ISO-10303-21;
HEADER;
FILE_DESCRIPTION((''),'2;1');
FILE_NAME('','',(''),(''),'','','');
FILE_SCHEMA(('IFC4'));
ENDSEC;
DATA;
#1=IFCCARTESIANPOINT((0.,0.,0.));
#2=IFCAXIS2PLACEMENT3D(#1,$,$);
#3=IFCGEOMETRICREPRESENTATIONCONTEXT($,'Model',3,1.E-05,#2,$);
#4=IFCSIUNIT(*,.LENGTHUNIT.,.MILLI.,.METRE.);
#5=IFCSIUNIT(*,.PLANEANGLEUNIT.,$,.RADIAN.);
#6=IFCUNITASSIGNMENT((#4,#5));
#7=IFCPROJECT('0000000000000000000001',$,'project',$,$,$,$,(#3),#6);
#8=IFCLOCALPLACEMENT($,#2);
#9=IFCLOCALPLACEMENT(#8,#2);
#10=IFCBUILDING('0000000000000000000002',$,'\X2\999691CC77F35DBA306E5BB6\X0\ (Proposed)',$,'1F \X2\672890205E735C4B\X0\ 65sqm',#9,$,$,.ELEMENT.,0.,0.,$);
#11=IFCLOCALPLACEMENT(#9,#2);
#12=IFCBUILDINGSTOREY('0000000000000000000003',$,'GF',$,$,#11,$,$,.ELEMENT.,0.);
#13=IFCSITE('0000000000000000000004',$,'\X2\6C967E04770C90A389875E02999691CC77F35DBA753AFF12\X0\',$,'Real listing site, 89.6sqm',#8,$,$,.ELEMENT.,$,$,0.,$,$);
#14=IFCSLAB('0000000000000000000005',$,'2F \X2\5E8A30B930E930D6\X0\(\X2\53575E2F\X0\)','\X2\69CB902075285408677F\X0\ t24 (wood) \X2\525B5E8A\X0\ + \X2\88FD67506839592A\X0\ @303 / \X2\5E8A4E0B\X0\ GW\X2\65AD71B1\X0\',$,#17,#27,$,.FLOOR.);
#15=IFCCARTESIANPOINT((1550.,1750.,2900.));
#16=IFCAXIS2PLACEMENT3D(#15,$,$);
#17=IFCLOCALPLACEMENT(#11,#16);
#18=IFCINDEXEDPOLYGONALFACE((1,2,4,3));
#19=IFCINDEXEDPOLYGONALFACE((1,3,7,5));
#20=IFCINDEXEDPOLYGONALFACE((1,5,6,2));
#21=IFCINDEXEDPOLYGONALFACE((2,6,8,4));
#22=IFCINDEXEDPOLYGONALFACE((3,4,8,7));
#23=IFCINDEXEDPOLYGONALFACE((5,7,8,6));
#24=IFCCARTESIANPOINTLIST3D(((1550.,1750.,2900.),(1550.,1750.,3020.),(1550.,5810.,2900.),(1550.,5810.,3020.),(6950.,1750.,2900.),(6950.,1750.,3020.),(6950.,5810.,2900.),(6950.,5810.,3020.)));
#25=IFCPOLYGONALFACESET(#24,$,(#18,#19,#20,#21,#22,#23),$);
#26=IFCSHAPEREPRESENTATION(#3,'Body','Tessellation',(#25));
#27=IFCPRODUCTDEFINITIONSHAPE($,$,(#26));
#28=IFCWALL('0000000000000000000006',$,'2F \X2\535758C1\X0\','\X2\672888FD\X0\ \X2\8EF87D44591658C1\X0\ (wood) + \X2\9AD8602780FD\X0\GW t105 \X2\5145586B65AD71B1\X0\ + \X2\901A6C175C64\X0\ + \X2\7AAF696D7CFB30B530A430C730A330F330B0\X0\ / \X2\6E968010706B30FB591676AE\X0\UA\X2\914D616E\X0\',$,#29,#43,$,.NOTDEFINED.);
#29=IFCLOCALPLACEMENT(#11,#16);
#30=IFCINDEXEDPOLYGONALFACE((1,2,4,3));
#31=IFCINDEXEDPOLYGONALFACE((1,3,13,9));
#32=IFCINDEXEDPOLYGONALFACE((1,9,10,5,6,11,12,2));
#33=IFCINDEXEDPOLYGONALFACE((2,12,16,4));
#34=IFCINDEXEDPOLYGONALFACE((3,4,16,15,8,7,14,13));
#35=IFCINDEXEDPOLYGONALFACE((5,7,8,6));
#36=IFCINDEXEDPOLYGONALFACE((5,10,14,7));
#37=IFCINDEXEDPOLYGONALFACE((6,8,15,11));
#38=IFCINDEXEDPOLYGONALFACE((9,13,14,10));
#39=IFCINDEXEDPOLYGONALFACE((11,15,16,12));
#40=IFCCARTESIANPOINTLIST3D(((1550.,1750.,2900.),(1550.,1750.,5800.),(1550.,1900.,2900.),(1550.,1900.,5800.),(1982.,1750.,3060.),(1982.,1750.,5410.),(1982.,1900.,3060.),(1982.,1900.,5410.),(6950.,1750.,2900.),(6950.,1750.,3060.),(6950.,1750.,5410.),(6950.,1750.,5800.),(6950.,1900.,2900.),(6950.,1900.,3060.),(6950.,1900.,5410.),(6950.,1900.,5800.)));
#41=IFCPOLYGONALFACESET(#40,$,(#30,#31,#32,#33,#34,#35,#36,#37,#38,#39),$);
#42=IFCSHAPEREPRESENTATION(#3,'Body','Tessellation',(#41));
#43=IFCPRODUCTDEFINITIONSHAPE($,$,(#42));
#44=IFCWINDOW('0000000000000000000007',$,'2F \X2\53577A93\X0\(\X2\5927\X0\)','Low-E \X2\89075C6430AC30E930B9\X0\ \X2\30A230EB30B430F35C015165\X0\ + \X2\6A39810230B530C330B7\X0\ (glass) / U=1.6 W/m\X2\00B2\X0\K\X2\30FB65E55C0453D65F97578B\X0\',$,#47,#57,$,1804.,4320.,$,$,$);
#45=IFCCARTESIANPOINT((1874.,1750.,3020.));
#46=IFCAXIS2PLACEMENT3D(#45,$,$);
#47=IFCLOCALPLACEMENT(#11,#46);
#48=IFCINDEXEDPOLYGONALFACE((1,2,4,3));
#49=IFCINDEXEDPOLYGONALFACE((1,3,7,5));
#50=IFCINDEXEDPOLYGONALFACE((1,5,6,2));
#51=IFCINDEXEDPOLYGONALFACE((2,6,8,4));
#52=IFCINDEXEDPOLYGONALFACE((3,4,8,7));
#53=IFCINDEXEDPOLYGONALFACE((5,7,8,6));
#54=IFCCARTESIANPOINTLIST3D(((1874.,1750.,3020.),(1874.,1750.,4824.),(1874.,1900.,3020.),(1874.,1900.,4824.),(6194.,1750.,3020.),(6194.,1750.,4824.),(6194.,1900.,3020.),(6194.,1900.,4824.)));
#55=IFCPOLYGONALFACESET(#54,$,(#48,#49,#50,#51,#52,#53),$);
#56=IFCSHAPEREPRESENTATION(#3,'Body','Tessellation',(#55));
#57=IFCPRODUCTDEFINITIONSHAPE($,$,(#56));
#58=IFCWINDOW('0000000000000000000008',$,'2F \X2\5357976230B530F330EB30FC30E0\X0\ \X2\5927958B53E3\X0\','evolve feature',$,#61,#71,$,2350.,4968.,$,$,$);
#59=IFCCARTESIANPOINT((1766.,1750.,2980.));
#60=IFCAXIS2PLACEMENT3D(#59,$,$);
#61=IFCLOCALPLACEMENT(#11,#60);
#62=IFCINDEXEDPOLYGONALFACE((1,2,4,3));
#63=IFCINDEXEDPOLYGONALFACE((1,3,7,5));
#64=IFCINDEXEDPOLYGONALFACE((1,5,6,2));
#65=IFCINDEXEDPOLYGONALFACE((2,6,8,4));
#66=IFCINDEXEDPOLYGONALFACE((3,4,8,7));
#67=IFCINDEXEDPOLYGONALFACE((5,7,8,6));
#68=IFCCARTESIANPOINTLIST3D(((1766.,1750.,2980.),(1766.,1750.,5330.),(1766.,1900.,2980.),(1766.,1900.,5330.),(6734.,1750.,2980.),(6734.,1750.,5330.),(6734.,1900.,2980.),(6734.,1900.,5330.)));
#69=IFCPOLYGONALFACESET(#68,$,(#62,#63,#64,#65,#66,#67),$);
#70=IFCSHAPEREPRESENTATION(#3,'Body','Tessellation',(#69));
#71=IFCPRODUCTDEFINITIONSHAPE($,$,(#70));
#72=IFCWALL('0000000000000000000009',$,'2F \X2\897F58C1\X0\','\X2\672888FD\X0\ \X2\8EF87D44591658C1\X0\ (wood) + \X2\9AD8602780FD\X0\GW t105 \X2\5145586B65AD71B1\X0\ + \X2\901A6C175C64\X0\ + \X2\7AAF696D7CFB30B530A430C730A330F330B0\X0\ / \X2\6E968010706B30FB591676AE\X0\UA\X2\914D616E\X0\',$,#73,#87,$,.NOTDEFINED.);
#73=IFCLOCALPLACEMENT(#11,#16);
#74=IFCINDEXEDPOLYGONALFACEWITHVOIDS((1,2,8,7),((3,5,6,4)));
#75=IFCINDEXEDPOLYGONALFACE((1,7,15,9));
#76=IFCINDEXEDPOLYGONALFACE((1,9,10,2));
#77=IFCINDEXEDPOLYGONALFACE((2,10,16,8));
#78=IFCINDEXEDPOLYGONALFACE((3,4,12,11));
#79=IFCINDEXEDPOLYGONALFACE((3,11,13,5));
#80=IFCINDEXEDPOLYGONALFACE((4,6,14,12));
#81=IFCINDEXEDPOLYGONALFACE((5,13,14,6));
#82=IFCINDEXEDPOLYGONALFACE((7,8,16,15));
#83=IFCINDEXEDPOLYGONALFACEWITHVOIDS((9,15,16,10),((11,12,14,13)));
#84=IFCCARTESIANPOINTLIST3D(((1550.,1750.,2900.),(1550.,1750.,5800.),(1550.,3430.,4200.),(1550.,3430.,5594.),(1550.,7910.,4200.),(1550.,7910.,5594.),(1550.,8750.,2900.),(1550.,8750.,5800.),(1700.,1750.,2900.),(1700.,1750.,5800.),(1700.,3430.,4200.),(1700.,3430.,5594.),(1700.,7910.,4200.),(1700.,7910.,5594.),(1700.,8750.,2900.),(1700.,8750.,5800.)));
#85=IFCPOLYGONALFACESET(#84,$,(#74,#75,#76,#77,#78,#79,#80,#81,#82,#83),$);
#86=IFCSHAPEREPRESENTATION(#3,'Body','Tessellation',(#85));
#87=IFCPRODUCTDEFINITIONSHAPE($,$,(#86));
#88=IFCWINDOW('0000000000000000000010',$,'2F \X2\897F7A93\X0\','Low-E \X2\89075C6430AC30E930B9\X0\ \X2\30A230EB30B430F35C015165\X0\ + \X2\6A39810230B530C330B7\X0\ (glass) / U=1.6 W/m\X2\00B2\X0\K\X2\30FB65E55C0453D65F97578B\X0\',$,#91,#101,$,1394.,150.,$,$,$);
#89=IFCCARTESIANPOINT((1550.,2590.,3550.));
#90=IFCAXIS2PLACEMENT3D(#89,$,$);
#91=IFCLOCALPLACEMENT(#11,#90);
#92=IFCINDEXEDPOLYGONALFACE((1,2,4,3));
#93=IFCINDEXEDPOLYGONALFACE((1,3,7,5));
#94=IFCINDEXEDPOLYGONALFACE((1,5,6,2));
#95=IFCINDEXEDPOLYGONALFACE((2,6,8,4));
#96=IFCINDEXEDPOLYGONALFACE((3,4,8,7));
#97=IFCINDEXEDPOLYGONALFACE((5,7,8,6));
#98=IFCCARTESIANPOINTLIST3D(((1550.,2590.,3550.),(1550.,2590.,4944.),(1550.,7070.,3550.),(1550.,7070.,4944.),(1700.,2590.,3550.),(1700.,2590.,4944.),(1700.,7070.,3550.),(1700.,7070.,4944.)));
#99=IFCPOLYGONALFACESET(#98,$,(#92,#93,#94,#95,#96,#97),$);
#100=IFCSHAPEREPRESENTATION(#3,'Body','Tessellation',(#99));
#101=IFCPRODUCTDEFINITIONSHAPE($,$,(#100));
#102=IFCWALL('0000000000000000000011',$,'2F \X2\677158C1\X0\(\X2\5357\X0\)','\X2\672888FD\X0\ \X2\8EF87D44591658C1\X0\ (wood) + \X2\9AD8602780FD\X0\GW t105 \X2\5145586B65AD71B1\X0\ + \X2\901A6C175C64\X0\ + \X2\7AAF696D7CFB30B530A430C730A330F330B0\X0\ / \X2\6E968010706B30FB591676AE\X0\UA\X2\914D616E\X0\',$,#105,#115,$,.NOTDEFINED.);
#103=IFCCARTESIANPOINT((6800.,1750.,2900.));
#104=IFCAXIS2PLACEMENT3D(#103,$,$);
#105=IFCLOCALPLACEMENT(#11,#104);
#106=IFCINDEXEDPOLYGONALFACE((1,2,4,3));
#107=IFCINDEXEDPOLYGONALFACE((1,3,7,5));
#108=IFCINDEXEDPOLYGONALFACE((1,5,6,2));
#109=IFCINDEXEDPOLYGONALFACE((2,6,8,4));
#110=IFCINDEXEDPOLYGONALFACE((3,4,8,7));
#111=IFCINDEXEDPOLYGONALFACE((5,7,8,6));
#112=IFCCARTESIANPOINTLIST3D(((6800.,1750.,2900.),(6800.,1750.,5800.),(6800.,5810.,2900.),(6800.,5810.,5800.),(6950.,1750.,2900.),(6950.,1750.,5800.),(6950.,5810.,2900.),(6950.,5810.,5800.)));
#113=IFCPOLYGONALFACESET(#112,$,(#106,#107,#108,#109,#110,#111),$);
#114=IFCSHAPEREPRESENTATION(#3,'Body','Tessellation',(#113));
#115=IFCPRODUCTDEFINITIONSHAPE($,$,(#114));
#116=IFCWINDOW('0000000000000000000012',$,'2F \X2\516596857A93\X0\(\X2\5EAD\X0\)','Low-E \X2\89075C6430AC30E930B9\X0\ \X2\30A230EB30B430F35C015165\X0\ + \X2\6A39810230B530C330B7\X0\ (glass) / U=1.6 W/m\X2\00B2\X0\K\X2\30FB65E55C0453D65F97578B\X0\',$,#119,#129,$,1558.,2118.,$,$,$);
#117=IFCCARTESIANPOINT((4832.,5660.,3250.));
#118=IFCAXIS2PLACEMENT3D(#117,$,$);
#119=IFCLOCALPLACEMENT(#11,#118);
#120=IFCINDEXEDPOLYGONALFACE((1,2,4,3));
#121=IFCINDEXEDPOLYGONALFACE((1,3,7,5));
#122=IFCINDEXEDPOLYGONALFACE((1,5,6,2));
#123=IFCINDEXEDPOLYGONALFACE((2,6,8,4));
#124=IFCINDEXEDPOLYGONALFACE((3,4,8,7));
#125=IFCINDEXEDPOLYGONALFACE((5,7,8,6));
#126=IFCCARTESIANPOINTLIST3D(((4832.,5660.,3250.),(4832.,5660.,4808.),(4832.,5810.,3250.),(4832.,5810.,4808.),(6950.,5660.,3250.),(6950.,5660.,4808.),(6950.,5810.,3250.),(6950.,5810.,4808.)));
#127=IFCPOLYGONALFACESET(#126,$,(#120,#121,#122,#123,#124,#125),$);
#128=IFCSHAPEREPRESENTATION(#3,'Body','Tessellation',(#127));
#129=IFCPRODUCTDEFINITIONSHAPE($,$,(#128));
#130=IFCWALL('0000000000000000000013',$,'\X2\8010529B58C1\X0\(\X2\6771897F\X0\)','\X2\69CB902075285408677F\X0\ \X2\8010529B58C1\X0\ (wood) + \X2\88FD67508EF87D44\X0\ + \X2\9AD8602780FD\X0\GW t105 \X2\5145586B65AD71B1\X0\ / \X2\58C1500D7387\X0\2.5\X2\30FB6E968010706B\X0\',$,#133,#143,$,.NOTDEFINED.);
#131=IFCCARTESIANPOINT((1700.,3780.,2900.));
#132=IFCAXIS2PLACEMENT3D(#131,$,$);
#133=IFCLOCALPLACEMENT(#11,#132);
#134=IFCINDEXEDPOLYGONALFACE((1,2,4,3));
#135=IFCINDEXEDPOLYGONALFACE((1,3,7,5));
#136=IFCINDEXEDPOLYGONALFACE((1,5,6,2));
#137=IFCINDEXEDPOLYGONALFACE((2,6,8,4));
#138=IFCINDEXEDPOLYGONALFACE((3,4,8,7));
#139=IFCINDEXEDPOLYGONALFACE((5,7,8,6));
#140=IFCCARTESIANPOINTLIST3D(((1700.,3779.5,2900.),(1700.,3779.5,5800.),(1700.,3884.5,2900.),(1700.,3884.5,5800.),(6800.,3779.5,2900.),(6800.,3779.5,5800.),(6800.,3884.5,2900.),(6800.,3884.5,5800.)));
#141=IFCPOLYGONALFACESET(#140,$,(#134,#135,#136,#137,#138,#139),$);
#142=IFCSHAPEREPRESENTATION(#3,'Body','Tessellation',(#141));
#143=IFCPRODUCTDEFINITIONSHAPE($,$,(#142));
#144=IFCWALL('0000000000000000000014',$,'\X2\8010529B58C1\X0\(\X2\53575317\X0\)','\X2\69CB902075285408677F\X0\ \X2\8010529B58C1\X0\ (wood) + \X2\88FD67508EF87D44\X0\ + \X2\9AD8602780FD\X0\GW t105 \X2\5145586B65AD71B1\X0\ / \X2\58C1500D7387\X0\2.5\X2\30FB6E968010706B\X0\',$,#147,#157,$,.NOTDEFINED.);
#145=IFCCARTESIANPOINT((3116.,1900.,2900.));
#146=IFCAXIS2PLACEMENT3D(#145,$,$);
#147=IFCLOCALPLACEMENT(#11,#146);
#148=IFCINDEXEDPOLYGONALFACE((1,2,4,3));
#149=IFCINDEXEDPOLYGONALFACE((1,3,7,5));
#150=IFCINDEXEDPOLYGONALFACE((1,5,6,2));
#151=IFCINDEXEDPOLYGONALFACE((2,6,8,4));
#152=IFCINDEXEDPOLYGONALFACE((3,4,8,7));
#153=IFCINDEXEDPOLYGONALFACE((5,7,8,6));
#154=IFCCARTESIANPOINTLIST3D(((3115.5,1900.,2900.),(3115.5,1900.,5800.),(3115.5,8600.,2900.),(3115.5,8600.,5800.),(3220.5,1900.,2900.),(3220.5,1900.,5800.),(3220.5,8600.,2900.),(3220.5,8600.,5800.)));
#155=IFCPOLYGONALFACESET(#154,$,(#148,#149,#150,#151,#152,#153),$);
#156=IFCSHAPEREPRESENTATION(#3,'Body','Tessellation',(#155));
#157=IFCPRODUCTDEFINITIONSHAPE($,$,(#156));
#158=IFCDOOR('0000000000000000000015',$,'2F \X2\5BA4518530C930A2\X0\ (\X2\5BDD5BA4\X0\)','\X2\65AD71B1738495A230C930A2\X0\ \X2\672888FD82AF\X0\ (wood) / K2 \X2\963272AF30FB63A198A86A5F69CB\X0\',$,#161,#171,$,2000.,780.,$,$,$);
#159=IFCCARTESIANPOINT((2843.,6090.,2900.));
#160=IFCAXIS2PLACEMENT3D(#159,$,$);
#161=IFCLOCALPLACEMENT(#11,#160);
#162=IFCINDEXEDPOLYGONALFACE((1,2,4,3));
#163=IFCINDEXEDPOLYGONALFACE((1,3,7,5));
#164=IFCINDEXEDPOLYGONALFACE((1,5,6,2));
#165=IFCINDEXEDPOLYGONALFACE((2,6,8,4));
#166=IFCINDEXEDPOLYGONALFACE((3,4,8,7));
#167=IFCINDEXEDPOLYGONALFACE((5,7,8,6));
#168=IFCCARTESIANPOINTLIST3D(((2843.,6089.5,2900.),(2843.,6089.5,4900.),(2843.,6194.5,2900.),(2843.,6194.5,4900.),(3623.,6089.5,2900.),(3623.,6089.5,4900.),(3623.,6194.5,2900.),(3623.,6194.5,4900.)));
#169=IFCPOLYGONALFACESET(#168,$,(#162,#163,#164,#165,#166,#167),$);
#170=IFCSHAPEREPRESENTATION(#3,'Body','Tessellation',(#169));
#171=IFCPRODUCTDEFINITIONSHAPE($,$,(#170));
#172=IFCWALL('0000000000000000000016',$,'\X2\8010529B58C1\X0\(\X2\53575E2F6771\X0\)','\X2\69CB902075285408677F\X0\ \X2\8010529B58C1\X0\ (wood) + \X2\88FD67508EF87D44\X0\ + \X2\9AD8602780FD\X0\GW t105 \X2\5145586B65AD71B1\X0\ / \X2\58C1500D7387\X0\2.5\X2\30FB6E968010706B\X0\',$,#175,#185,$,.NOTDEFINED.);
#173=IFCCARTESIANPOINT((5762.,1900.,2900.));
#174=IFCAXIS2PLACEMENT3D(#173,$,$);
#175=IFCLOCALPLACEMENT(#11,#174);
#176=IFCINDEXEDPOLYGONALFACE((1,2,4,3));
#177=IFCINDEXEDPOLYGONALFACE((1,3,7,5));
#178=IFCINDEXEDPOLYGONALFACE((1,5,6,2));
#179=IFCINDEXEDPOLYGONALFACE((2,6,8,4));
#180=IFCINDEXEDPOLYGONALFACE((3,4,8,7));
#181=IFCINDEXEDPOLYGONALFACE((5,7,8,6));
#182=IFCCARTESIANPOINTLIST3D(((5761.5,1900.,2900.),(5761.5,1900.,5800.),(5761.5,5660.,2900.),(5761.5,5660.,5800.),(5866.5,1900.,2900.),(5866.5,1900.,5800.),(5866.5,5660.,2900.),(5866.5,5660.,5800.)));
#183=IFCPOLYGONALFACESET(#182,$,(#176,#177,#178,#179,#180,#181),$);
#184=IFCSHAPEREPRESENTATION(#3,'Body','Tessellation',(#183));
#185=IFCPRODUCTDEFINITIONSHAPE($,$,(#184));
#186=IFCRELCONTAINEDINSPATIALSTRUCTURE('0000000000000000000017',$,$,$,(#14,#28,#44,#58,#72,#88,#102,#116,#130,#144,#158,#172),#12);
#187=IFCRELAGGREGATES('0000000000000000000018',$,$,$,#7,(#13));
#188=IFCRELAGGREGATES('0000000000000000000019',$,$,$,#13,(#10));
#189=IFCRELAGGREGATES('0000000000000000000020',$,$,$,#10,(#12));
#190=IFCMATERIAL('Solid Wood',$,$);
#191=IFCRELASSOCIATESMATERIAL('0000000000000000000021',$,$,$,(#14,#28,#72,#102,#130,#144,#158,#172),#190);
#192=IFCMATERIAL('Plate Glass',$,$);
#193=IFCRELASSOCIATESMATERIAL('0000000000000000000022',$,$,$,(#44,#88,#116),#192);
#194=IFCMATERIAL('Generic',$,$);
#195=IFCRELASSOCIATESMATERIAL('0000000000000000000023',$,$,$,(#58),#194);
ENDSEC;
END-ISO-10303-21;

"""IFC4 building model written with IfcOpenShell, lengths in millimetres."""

from ifc_helpers import new_model, si_unit, frame, frame_2d, origin, place, context, project, spatial, rectangle, extrude, material, element, fill, save


model = new_model("IFC4")

# Units and contexts
model_context = context("Model", 3, precision=1e-05, world=origin())
ifc_project = project(units=[si_unit("LENGTHUNIT", "METRE", prefix="MILLI"), si_unit("PLANEANGLEUNIT", "RADIAN")], contexts=[model_context])

# Site, building, storey
site_placement = place(None, origin())
site = spatial("IfcSite", under=ifc_project, at=site_placement, Name="沖縄県那覇市首里石嶺町２", ObjectType="Real listing site, 89.6sqm", CompositionType="ELEMENT", RefElevation=0.0)
building_placement = place(site_placement, origin())
building = spatial("IfcBuilding", under=site, at=building_placement, Name="首里石嶺の家 (Proposed)", ObjectType="1F 木造平屋 65sqm", CompositionType="ELEMENT", ElevationOfRefHeight=0.0, ElevationOfTerrain=0.0)
storey_placement = place(building_placement, origin())
storey = spatial("IfcBuildingStorey", under=building, at=storey_placement, Name="GF", CompositionType="ELEMENT", Elevation=0.0)

# Slab
ifc_material_1 = material(Name="Solid Wood")
slab_placement = place(storey_placement, frame((1550.0, 1750.0, 2900.0)))
element("IfcSlab", 1, at=slab_placement, inside=storey, material=ifc_material_1, Name="2F 床スラブ(南帯)", Description="構造用合板 t24 (wood) 剛床 + 製材根太 @303 / 床下 GW断熱", PredefinedType="FLOOR", context=model_context, shape_type="SweptSolid", body=[
    extrude(rectangle(XDim=5400.0, YDim=4060.0, at=frame_2d((2700.0, 2030.0))), frame((1550.0, 1750.0, 2900.0)), (0.0, 0.0, 1.0), 120.0),
])

# Wall, openings, windows
wall_1_placement = place(storey_placement, frame((1550.0, 1750.0, 2900.0)))
wall_1 = element("IfcWall", 2, at=wall_1_placement, inside=storey, material=ifc_material_1, Name="2F 南壁", Description="木製 軸組外壁 (wood) + 高性能GW t105 充填断熱 + 通気層 + 窯業系サイディング / 準耐火・外皮UA配慮", PredefinedType="NOTDEFINED", context=model_context, shape_type="SweptSolid", body=[
    extrude(rectangle(XDim=5400.0, YDim=150.0, at=frame_2d((2700.0, 75.0))), frame((1550.0, 1750.0, 2900.0)), (0.0, 0.0, 1.0), 2900.0),
])
opening_1_placement = place(storey_placement, frame((1874.0, 1750.0, 3020.0)))
opening_1 = element("IfcOpeningElement", 3, at=opening_1_placement, cuts=wall_1, PredefinedType="NOTDEFINED", context=model_context, shape_type="SweptSolid", body=[
    extrude(rectangle(XDim=4320.0, YDim=150.0, at=frame_2d((2160.0, 75.0))), frame((1874.0, 1750.0, 3020.0)), (0.0, 0.0, 1.0), 1804.0),
])
opening_2_placement = place(storey_placement, frame((1766.0, 1750.0, 2980.0)))
opening_2 = element("IfcOpeningElement", 4, at=opening_2_placement, cuts=wall_1, PredefinedType="NOTDEFINED", context=model_context, shape_type="SweptSolid", body=[
    extrude(rectangle(XDim=4968.0, YDim=150.0, at=frame_2d((2484.0, 75.0))), frame((1766.0, 1750.0, 2980.0)), (0.0, 0.0, 1.0), 2350.0),
])
ifc_material_2 = material(Name="Plate Glass")
window_1_placement = place(storey_placement, frame((1874.0, 1750.0, 3020.0)))
window_1 = element("IfcWindow", 5, at=window_1_placement, inside=storey, material=ifc_material_2, Name="2F 南窓(大)", Description="Low-E 複層ガラス アルゴン封入 + 樹脂サッシ (glass) / U=1.6 W/m²K・日射取得型", OverallHeight=1804.0, OverallWidth=4320.0, context=model_context, shape_type="SweptSolid", body=[
    extrude(rectangle(XDim=4320.0, YDim=150.0, at=frame_2d((2160.0, 75.0))), frame((1874.0, 1750.0, 3020.0)), (0.0, 0.0, 1.0), 1804.0),
])
fill(opening_1, window_1)
ifc_material_3 = material(Name="Generic")
window_2_placement = place(storey_placement, frame((1766.0, 1750.0, 2980.0)))
window_2 = element("IfcWindow", 6, at=window_2_placement, inside=storey, material=ifc_material_3, Name="2F 南面サンルーム 大開口", Description="evolve feature", OverallHeight=2350.0, OverallWidth=4968.0, context=model_context, shape_type="SweptSolid", body=[
    extrude(rectangle(XDim=4968.0, YDim=150.0, at=frame_2d((2484.0, 75.0))), frame((1766.0, 1750.0, 2980.0)), (0.0, 0.0, 1.0), 2350.0),
])
fill(opening_2, window_2)

# Walls, openings, windows
wall_2_placement = place(storey_placement, frame((1550.0, 1750.0, 2900.0)))
wall_2 = element("IfcWall", 7, at=wall_2_placement, inside=storey, material=ifc_material_1, Name="2F 西壁", Description="木製 軸組外壁 (wood) + 高性能GW t105 充填断熱 + 通気層 + 窯業系サイディング / 準耐火・外皮UA配慮", PredefinedType="NOTDEFINED", context=model_context, shape_type="SweptSolid", body=[
    extrude(rectangle(XDim=150.0, YDim=7000.0, at=frame_2d((75.0, 3500.0))), frame((1550.0, 1750.0, 2900.0)), (0.0, 0.0, 1.0), 2900.0),
])
opening_3_placement = place(storey_placement, frame((1550.0, 2590.0, 3550.0)))
opening_3 = element("IfcOpeningElement", 8, at=opening_3_placement, cuts=wall_2, PredefinedType="NOTDEFINED", context=model_context, shape_type="SweptSolid", body=[
    extrude(rectangle(XDim=150.0, YDim=4480.0, at=frame_2d((75.0, 2240.0))), frame((1550.0, 2590.0, 3550.0)), (0.0, 0.0, 1.0), 1394.0),
])
window_3_placement = place(storey_placement, frame((1550.0, 2590.0, 3550.0)))
window_3 = element("IfcWindow", 9, at=window_3_placement, inside=storey, material=ifc_material_2, Name="2F 西窓", Description="Low-E 複層ガラス アルゴン封入 + 樹脂サッシ (glass) / U=1.6 W/m²K・日射取得型", OverallHeight=1394.0, OverallWidth=150.0, context=model_context, shape_type="SweptSolid", body=[
    extrude(rectangle(XDim=150.0, YDim=4480.0, at=frame_2d((75.0, 2240.0))), frame((1550.0, 2590.0, 3550.0)), (0.0, 0.0, 1.0), 1394.0),
])
fill(opening_3, window_3)
wall_3_placement = place(storey_placement, frame((6800.0, 1750.0, 2900.0)))
wall_3 = element("IfcWall", 10, at=wall_3_placement, inside=storey, material=ifc_material_1, Name="2F 東壁(南)", Description="木製 軸組外壁 (wood) + 高性能GW t105 充填断熱 + 通気層 + 窯業系サイディング / 準耐火・外皮UA配慮", PredefinedType="NOTDEFINED", context=model_context, shape_type="SweptSolid", body=[
    extrude(rectangle(XDim=150.0, YDim=4060.0, at=frame_2d((75.0, 2030.0))), frame((6800.0, 1750.0, 2900.0)), (0.0, 0.0, 1.0), 2900.0),
])
opening_4_placement = place(storey_placement, frame((4832.0, 5660.0, 3250.0)))
opening_4 = element("IfcOpeningElement", 11, at=opening_4_placement, cuts=wall_3, PredefinedType="NOTDEFINED", context=model_context, shape_type="SweptSolid", body=[
    extrude(rectangle(XDim=2118.0, YDim=150.0, at=frame_2d((1059.0, 75.0))), frame((4832.0, 5660.0, 3250.0)), (0.0, 0.0, 1.0), 1558.0),
])
window_4_placement = place(storey_placement, frame((4832.0, 5660.0, 3250.0)))
window_4 = element("IfcWindow", 12, at=window_4_placement, inside=storey, material=ifc_material_2, Name="2F 入隅窓(庭)", Description="Low-E 複層ガラス アルゴン封入 + 樹脂サッシ (glass) / U=1.6 W/m²K・日射取得型", OverallHeight=1558.0, OverallWidth=2118.0, context=model_context, shape_type="SweptSolid", body=[
    extrude(rectangle(XDim=2118.0, YDim=150.0, at=frame_2d((1059.0, 75.0))), frame((4832.0, 5660.0, 3250.0)), (0.0, 0.0, 1.0), 1558.0),
])
fill(opening_4, window_4)

# Wall
wall_4_placement = place(storey_placement, frame((1700.0, 3780.0, 2900.0)))
element("IfcWall", 13, at=wall_4_placement, inside=storey, material=ifc_material_1, Name="耐力壁(東西)", Description="構造用合板 耐力壁 (wood) + 製材軸組 + 高性能GW t105 充填断熱 / 壁倍率2.5・準耐火", PredefinedType="NOTDEFINED", context=model_context, shape_type="SweptSolid", body=[
    extrude(rectangle(XDim=5100.0, YDim=105.0, at=frame_2d((2550.0, 52.0))), frame((1700.0, 3780.0, 2900.0)), (0.0, 0.0, 1.0), 2900.0),
])

# Wall, opening, door
wall_5_placement = place(storey_placement, frame((3116.0, 1900.0, 2900.0)))
wall_5 = element("IfcWall", 14, at=wall_5_placement, inside=storey, material=ifc_material_1, Name="耐力壁(南北)", Description="構造用合板 耐力壁 (wood) + 製材軸組 + 高性能GW t105 充填断熱 / 壁倍率2.5・準耐火", PredefinedType="NOTDEFINED", context=model_context, shape_type="SweptSolid", body=[
    extrude(rectangle(XDim=105.0, YDim=6700.0, at=frame_2d((52.0, 3350.0))), frame((3116.0, 1900.0, 2900.0)), (0.0, 0.0, 1.0), 2900.0),
])
opening_5_placement = place(storey_placement, frame((2843.0, 6090.0, 2900.0)))
opening_5 = element("IfcOpeningElement", 15, at=opening_5_placement, cuts=wall_5, PredefinedType="NOTDEFINED", context=model_context, shape_type="SweptSolid", body=[
    extrude(rectangle(XDim=780.0, YDim=105.0, at=frame_2d((390.0, 52.0))), frame((2843.0, 6090.0, 2900.0)), (0.0, 0.0, 1.0), 2000.0),
])
door_placement = place(storey_placement, frame((2843.0, 6090.0, 2900.0)))
door = element("IfcDoor", 16, at=door_placement, inside=storey, material=ifc_material_1, Name="2F 室内ドア (寝室)", Description="断熱玄関ドア 木製芯 (wood) / K2 防犯・採風機構", OverallHeight=2000.0, OverallWidth=780.0, context=model_context, shape_type="SweptSolid", body=[
    extrude(rectangle(XDim=780.0, YDim=105.0, at=frame_2d((390.0, 52.0))), frame((2843.0, 6090.0, 2900.0)), (0.0, 0.0, 1.0), 2000.0),
])
fill(opening_5, door)

# Wall
wall_6_placement = place(storey_placement, frame((5762.0, 1900.0, 2900.0)))
element("IfcWall", 17, at=wall_6_placement, inside=storey, material=ifc_material_1, Name="耐力壁(南帯東)", Description="構造用合板 耐力壁 (wood) + 製材軸組 + 高性能GW t105 充填断熱 / 壁倍率2.5・準耐火", PredefinedType="NOTDEFINED", context=model_context, shape_type="SweptSolid", body=[
    extrude(rectangle(XDim=105.0, YDim=3760.0, at=frame_2d((52.0, 1880.0))), frame((5762.0, 1900.0, 2900.0)), (0.0, 0.0, 1.0), 2900.0),
])

save(model, "model.ifc")
